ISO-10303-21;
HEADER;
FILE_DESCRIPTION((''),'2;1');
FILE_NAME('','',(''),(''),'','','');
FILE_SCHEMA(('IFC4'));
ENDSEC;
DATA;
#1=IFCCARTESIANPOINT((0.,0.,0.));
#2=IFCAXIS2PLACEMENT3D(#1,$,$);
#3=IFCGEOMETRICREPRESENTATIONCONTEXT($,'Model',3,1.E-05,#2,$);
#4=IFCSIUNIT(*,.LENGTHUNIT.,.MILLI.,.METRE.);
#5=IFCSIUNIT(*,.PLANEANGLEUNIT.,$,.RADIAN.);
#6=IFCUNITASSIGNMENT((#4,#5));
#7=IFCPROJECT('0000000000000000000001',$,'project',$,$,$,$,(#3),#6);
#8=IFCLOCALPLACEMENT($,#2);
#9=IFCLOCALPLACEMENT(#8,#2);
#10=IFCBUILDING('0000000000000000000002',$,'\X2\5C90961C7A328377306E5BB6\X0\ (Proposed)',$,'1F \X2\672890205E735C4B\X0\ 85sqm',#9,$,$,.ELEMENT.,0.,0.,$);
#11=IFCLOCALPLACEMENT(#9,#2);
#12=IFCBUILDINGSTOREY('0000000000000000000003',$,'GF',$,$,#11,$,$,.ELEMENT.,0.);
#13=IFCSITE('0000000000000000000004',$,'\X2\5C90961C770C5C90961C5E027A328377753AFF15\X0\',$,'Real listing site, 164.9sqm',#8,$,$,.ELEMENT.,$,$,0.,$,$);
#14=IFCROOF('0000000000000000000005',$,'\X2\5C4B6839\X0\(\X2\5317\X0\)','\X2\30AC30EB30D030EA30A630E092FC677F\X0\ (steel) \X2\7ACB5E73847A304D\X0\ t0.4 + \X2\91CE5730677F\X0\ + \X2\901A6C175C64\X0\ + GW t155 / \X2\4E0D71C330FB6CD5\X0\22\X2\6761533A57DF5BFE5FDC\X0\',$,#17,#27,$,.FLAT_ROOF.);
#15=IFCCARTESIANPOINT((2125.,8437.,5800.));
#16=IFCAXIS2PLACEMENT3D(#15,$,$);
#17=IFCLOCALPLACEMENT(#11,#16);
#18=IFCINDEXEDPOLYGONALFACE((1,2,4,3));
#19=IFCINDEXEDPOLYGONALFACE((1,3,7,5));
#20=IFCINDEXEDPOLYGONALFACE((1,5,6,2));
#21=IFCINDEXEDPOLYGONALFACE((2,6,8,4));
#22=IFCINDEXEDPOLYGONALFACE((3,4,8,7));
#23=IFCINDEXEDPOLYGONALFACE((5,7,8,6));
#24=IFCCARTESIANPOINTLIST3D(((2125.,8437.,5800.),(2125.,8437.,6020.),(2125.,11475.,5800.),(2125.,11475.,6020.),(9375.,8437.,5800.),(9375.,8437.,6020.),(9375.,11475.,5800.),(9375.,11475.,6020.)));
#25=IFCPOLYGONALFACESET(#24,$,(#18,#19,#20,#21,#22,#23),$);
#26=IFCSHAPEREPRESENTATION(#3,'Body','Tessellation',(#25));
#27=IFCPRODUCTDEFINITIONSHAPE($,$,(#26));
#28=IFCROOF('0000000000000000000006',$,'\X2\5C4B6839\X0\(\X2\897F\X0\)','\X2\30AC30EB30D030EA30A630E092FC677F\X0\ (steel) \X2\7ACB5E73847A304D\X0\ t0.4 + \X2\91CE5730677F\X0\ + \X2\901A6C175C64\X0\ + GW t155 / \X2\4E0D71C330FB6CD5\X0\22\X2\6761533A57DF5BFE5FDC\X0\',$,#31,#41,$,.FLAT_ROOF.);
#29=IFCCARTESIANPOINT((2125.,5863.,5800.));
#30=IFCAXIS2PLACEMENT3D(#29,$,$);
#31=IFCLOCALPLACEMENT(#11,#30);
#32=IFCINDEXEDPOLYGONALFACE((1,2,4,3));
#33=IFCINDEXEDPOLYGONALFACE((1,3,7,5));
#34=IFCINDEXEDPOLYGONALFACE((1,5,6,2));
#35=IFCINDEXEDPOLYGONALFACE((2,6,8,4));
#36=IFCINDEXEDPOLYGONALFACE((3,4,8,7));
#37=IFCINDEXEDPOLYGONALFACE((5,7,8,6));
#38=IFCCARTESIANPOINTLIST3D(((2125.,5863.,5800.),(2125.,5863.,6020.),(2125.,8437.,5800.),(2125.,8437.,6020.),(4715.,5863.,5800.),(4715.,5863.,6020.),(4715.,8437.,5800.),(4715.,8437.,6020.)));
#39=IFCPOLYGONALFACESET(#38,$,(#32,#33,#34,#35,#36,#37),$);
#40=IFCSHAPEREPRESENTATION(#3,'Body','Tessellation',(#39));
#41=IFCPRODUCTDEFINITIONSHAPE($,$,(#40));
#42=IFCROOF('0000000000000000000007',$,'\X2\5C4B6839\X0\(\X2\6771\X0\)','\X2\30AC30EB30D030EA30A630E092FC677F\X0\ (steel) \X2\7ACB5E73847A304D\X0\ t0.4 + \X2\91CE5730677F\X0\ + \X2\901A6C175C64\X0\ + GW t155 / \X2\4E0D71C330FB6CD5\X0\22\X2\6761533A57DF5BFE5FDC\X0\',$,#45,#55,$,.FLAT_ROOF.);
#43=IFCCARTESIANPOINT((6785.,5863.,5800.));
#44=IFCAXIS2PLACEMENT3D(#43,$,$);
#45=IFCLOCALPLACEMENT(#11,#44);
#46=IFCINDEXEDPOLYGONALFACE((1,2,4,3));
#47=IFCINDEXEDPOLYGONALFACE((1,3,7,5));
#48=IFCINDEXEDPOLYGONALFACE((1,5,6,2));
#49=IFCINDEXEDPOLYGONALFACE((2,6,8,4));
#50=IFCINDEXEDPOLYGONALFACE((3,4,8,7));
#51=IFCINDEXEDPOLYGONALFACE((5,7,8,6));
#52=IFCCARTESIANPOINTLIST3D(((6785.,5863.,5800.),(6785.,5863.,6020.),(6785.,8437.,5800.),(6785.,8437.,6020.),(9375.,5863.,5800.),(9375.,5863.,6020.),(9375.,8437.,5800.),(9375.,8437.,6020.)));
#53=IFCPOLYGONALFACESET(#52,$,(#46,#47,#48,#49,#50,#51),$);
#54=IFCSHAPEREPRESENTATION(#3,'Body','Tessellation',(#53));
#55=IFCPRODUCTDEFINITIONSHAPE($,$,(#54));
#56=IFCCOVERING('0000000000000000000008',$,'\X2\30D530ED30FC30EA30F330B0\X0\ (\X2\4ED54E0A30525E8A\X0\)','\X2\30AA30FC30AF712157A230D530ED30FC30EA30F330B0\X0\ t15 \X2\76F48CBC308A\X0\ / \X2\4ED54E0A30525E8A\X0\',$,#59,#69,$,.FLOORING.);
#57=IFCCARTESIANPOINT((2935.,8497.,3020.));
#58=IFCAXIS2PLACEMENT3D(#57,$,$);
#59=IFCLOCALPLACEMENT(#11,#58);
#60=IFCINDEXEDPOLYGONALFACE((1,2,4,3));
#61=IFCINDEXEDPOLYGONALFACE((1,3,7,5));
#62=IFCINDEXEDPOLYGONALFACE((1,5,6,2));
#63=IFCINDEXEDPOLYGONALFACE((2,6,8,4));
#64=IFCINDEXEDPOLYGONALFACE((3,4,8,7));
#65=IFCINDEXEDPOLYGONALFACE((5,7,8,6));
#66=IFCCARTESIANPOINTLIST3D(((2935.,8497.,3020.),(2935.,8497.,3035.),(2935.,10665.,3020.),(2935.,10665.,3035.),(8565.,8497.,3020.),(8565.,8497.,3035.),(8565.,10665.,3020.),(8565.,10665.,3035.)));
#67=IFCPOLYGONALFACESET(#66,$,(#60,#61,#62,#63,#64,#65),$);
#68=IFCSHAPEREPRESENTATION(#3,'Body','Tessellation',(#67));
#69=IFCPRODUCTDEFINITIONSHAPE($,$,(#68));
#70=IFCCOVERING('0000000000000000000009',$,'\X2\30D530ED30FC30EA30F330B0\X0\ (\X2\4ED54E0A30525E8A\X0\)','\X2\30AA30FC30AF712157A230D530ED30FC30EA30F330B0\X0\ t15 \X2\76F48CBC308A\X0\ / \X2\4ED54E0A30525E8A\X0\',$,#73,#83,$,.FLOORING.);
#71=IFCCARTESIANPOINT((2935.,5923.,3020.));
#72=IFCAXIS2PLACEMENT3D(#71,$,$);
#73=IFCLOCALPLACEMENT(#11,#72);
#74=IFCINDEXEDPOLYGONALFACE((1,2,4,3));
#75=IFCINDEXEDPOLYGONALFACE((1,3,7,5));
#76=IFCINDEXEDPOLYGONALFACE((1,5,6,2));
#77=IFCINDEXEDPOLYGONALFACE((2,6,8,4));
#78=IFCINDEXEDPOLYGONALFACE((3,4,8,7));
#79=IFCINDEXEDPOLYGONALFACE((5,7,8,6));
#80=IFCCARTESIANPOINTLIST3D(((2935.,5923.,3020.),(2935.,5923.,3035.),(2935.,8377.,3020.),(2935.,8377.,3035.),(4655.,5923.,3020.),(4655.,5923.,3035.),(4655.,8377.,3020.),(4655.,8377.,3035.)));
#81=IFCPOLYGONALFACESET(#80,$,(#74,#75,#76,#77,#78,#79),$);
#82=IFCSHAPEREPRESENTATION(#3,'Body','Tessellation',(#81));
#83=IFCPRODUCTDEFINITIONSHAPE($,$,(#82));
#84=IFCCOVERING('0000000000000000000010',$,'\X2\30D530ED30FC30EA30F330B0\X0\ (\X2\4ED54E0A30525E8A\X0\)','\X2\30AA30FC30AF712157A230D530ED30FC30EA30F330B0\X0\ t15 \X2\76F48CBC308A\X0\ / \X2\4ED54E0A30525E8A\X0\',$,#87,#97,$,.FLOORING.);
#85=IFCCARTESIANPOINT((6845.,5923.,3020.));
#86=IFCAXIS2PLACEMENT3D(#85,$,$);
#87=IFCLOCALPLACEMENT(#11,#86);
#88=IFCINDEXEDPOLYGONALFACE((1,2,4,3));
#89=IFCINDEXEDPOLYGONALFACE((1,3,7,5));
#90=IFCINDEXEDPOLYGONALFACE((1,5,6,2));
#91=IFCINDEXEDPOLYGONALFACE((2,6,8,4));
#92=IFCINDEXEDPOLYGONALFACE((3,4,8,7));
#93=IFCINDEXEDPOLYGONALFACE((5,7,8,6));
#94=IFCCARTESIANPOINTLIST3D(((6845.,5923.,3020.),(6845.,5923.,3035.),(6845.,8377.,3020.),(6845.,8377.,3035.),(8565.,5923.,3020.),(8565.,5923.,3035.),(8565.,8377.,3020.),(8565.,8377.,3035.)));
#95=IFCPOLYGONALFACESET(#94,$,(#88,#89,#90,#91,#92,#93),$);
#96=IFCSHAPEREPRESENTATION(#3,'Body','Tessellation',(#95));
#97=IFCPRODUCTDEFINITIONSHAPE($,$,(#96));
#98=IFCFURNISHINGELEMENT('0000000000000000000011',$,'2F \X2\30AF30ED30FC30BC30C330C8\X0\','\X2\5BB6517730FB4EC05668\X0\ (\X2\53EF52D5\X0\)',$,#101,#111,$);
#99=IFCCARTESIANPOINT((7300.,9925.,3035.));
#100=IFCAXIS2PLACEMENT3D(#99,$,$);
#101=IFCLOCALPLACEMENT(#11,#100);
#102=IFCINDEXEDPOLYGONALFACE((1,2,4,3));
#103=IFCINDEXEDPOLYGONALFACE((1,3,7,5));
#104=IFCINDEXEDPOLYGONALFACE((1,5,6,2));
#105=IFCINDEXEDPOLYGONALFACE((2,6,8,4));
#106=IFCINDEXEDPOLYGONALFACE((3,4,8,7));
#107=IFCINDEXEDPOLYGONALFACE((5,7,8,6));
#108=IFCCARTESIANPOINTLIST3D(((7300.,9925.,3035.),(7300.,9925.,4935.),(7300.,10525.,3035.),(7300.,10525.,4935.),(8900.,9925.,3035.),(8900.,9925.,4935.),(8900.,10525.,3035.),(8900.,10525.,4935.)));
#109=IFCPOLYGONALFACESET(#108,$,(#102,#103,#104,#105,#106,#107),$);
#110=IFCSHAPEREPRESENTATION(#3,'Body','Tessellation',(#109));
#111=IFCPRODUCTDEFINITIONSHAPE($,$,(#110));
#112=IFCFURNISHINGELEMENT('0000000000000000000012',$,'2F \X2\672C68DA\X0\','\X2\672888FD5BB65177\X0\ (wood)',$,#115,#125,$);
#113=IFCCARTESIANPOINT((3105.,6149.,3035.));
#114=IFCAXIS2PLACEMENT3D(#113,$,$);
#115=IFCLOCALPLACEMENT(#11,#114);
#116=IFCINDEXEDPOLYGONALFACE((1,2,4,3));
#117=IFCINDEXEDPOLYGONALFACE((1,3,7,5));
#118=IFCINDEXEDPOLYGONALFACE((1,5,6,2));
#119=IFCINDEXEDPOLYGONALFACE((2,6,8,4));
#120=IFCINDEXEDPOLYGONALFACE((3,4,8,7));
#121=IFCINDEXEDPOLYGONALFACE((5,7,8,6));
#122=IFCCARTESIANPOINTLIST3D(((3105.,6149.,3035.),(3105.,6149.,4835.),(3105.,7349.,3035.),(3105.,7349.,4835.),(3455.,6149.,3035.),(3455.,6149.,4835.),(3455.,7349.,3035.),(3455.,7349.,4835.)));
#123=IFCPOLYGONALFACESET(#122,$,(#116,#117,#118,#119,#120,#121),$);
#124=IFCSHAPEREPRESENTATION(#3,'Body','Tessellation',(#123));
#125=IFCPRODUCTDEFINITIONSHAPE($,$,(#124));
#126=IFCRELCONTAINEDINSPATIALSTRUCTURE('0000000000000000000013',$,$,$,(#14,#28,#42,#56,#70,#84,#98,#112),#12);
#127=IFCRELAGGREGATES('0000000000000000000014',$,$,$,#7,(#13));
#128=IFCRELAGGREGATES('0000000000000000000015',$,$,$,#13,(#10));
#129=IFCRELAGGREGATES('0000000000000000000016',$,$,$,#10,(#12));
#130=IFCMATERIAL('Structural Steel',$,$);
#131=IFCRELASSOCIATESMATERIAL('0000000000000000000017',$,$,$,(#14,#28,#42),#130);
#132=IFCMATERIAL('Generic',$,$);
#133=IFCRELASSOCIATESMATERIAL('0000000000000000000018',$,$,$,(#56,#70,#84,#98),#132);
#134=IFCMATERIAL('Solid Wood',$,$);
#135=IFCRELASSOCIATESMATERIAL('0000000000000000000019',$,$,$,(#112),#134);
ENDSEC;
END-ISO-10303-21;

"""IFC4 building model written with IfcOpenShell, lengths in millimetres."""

from ifc_helpers import new_model, si_unit, frame, frame_2d, origin, place, context, project, spatial, rectangle, extrude, material, element, save


model = new_model("IFC4")

# Units and contexts
model_context = context("Model", 3, precision=1e-05, world=origin())
ifc_project = project(units=[si_unit("LENGTHUNIT", "METRE", prefix="MILLI"), si_unit("PLANEANGLEUNIT", "RADIAN")], contexts=[model_context])

# Site, building, storey
site_placement = place(None, origin())
site = spatial("IfcSite", under=ifc_project, at=site_placement, Name="岐阜県岐阜市稲荷町５", ObjectType="Real listing site, 164.9sqm", CompositionType="ELEMENT", RefElevation=0.0)
building_placement = place(site_placement, origin())
building = spatial("IfcBuilding", under=site, at=building_placement, Name="岐阜稲荷の家 (Proposed)", ObjectType="1F 木造平屋 85sqm", CompositionType="ELEMENT", ElevationOfRefHeight=0.0, ElevationOfTerrain=0.0)
storey_placement = place(building_placement, origin())
storey = spatial("IfcBuildingStorey", under=building, at=storey_placement, Name="GF", CompositionType="ELEMENT", Elevation=0.0)

# Shared definitions
ifc_material_1 = material(Name="Solid Wood")

# Shared definitions
ifc_material_2 = material(Name="Generic")

# Roofs
ifc_material_3 = material(Name="Structural Steel")
for number, where, name in (
    (1, (2125.0, 8437.0, 5800.0), "屋根(北)"),
):
    element("IfcRoof", number, at=place(storey_placement, frame(where)), inside=storey, material=ifc_material_3, Name=name, Description="ガルバリウム鋼板 (steel) 立平葺き t0.4 + 野地板 + 通気層 + GW t155 / 不燃・法22条区域対応", PredefinedType="FLAT_ROOF", context=model_context, shape_type="SweptSolid", body=[
        extrude(rectangle(XDim=7250.0, YDim=3038.0, at=frame_2d((3625.0, 1519.0))), frame((2125.0, 8437.0, 5800.0)), (0.0, 0.0, 1.0), 220.0),
    ])
roof_1_placement = place(storey_placement, frame((2125.0, 5863.0, 5800.0)))
element("IfcRoof", 2, at=roof_1_placement, inside=storey, material=ifc_material_3, Name="屋根(西)", Description="ガルバリウム鋼板 (steel) 立平葺き t0.4 + 野地板 + 通気層 + GW t155 / 不燃・法22条区域対応", PredefinedType="FLAT_ROOF", context=model_context, shape_type="SweptSolid", body=[
    extrude(rectangle(XDim=2590.0, YDim=2574.0, at=frame_2d((1295.0, 1287.0))), frame((2125.0, 5863.0, 5800.0)), (0.0, 0.0, 1.0), 220.0),
])
roof_2_placement = place(storey_placement, frame((6785.0, 5863.0, 5800.0)))
element("IfcRoof", 3, at=roof_2_placement, inside=storey, material=ifc_material_3, Name="屋根(東)", Description="ガルバリウム鋼板 (steel) 立平葺き t0.4 + 野地板 + 通気層 + GW t155 / 不燃・法22条区域対応", PredefinedType="FLAT_ROOF", context=model_context, shape_type="SweptSolid", body=[
    extrude(rectangle(XDim=2590.0, YDim=2574.0, at=frame_2d((1295.0, 1287.0))), frame((6785.0, 5863.0, 5800.0)), (0.0, 0.0, 1.0), 220.0),
])

# Coverings
covering_1_placement = place(storey_placement, frame((2935.0, 8497.0, 3020.0)))
element("IfcCovering", 4, at=covering_1_placement, inside=storey, material=ifc_material_2, Name="フローリング (仕上げ床)", Description="オーク無垢フローリング t15 直貼り / 仕上げ床", PredefinedType="FLOORING", context=model_context, shape_type="SweptSolid", body=[
    extrude(rectangle(XDim=5630.0, YDim=2168.0, at=frame_2d((2815.0, 1084.0))), frame((2935.0, 8497.0, 3020.0)), (0.0, 0.0, 1.0), 15.0),
])
covering_2_placement = place(storey_placement, frame((2935.0, 5923.0, 3020.0)))
element("IfcCovering", 5, at=covering_2_placement, inside=storey, material=ifc_material_2, Name="フローリング (仕上げ床)", Description="オーク無垢フローリング t15 直貼り / 仕上げ床", PredefinedType="FLOORING", context=model_context, shape_type="SweptSolid", body=[
    extrude(rectangle(XDim=1720.0, YDim=2454.0, at=frame_2d((860.0, 1227.0))), frame((2935.0, 5923.0, 3020.0)), (0.0, 0.0, 1.0), 15.0),
])
covering_3_placement = place(storey_placement, frame((6845.0, 5923.0, 3020.0)))
element("IfcCovering", 6, at=covering_3_placement, inside=storey, material=ifc_material_2, Name="フローリング (仕上げ床)", Description="オーク無垢フローリング t15 直貼り / 仕上げ床", PredefinedType="FLOORING", context=model_context, shape_type="SweptSolid", body=[
    extrude(rectangle(XDim=1720.0, YDim=2454.0, at=frame_2d((860.0, 1227.0))), frame((6845.0, 5923.0, 3020.0)), (0.0, 0.0, 1.0), 15.0),
])

# Furnishing elements
furnishing_1_placement = place(storey_placement, frame((7300.0, 9925.0, 3035.0)))
element("IfcFurnishingElement", 7, at=furnishing_1_placement, inside=storey, material=ifc_material_2, Name="2F クローゼット", Description="家具・什器 (可動)", context=model_context, shape_type="SweptSolid", body=[
    extrude(rectangle(XDim=1600.0, YDim=600.0, at=frame_2d((800.0, 300.0))), frame((7300.0, 9925.0, 3035.0)), (0.0, 0.0, 1.0), 1900.0),
])
furnishing_2_placement = place(storey_placement, frame((3105.0, 6149.0, 3035.0)))
element("IfcFurnishingElement", 8, at=furnishing_2_placement, inside=storey, material=ifc_material_1, Name="2F 本棚", Description="木製家具 (wood)", context=model_context, shape_type="SweptSolid", body=[
    extrude(rectangle(XDim=350.0, YDim=1200.0, at=frame_2d((175.0, 600.0))), frame((3105.0, 6149.0, 3035.0)), (0.0, 0.0, 1.0), 1800.0),
])

save(model, "model.ifc")
